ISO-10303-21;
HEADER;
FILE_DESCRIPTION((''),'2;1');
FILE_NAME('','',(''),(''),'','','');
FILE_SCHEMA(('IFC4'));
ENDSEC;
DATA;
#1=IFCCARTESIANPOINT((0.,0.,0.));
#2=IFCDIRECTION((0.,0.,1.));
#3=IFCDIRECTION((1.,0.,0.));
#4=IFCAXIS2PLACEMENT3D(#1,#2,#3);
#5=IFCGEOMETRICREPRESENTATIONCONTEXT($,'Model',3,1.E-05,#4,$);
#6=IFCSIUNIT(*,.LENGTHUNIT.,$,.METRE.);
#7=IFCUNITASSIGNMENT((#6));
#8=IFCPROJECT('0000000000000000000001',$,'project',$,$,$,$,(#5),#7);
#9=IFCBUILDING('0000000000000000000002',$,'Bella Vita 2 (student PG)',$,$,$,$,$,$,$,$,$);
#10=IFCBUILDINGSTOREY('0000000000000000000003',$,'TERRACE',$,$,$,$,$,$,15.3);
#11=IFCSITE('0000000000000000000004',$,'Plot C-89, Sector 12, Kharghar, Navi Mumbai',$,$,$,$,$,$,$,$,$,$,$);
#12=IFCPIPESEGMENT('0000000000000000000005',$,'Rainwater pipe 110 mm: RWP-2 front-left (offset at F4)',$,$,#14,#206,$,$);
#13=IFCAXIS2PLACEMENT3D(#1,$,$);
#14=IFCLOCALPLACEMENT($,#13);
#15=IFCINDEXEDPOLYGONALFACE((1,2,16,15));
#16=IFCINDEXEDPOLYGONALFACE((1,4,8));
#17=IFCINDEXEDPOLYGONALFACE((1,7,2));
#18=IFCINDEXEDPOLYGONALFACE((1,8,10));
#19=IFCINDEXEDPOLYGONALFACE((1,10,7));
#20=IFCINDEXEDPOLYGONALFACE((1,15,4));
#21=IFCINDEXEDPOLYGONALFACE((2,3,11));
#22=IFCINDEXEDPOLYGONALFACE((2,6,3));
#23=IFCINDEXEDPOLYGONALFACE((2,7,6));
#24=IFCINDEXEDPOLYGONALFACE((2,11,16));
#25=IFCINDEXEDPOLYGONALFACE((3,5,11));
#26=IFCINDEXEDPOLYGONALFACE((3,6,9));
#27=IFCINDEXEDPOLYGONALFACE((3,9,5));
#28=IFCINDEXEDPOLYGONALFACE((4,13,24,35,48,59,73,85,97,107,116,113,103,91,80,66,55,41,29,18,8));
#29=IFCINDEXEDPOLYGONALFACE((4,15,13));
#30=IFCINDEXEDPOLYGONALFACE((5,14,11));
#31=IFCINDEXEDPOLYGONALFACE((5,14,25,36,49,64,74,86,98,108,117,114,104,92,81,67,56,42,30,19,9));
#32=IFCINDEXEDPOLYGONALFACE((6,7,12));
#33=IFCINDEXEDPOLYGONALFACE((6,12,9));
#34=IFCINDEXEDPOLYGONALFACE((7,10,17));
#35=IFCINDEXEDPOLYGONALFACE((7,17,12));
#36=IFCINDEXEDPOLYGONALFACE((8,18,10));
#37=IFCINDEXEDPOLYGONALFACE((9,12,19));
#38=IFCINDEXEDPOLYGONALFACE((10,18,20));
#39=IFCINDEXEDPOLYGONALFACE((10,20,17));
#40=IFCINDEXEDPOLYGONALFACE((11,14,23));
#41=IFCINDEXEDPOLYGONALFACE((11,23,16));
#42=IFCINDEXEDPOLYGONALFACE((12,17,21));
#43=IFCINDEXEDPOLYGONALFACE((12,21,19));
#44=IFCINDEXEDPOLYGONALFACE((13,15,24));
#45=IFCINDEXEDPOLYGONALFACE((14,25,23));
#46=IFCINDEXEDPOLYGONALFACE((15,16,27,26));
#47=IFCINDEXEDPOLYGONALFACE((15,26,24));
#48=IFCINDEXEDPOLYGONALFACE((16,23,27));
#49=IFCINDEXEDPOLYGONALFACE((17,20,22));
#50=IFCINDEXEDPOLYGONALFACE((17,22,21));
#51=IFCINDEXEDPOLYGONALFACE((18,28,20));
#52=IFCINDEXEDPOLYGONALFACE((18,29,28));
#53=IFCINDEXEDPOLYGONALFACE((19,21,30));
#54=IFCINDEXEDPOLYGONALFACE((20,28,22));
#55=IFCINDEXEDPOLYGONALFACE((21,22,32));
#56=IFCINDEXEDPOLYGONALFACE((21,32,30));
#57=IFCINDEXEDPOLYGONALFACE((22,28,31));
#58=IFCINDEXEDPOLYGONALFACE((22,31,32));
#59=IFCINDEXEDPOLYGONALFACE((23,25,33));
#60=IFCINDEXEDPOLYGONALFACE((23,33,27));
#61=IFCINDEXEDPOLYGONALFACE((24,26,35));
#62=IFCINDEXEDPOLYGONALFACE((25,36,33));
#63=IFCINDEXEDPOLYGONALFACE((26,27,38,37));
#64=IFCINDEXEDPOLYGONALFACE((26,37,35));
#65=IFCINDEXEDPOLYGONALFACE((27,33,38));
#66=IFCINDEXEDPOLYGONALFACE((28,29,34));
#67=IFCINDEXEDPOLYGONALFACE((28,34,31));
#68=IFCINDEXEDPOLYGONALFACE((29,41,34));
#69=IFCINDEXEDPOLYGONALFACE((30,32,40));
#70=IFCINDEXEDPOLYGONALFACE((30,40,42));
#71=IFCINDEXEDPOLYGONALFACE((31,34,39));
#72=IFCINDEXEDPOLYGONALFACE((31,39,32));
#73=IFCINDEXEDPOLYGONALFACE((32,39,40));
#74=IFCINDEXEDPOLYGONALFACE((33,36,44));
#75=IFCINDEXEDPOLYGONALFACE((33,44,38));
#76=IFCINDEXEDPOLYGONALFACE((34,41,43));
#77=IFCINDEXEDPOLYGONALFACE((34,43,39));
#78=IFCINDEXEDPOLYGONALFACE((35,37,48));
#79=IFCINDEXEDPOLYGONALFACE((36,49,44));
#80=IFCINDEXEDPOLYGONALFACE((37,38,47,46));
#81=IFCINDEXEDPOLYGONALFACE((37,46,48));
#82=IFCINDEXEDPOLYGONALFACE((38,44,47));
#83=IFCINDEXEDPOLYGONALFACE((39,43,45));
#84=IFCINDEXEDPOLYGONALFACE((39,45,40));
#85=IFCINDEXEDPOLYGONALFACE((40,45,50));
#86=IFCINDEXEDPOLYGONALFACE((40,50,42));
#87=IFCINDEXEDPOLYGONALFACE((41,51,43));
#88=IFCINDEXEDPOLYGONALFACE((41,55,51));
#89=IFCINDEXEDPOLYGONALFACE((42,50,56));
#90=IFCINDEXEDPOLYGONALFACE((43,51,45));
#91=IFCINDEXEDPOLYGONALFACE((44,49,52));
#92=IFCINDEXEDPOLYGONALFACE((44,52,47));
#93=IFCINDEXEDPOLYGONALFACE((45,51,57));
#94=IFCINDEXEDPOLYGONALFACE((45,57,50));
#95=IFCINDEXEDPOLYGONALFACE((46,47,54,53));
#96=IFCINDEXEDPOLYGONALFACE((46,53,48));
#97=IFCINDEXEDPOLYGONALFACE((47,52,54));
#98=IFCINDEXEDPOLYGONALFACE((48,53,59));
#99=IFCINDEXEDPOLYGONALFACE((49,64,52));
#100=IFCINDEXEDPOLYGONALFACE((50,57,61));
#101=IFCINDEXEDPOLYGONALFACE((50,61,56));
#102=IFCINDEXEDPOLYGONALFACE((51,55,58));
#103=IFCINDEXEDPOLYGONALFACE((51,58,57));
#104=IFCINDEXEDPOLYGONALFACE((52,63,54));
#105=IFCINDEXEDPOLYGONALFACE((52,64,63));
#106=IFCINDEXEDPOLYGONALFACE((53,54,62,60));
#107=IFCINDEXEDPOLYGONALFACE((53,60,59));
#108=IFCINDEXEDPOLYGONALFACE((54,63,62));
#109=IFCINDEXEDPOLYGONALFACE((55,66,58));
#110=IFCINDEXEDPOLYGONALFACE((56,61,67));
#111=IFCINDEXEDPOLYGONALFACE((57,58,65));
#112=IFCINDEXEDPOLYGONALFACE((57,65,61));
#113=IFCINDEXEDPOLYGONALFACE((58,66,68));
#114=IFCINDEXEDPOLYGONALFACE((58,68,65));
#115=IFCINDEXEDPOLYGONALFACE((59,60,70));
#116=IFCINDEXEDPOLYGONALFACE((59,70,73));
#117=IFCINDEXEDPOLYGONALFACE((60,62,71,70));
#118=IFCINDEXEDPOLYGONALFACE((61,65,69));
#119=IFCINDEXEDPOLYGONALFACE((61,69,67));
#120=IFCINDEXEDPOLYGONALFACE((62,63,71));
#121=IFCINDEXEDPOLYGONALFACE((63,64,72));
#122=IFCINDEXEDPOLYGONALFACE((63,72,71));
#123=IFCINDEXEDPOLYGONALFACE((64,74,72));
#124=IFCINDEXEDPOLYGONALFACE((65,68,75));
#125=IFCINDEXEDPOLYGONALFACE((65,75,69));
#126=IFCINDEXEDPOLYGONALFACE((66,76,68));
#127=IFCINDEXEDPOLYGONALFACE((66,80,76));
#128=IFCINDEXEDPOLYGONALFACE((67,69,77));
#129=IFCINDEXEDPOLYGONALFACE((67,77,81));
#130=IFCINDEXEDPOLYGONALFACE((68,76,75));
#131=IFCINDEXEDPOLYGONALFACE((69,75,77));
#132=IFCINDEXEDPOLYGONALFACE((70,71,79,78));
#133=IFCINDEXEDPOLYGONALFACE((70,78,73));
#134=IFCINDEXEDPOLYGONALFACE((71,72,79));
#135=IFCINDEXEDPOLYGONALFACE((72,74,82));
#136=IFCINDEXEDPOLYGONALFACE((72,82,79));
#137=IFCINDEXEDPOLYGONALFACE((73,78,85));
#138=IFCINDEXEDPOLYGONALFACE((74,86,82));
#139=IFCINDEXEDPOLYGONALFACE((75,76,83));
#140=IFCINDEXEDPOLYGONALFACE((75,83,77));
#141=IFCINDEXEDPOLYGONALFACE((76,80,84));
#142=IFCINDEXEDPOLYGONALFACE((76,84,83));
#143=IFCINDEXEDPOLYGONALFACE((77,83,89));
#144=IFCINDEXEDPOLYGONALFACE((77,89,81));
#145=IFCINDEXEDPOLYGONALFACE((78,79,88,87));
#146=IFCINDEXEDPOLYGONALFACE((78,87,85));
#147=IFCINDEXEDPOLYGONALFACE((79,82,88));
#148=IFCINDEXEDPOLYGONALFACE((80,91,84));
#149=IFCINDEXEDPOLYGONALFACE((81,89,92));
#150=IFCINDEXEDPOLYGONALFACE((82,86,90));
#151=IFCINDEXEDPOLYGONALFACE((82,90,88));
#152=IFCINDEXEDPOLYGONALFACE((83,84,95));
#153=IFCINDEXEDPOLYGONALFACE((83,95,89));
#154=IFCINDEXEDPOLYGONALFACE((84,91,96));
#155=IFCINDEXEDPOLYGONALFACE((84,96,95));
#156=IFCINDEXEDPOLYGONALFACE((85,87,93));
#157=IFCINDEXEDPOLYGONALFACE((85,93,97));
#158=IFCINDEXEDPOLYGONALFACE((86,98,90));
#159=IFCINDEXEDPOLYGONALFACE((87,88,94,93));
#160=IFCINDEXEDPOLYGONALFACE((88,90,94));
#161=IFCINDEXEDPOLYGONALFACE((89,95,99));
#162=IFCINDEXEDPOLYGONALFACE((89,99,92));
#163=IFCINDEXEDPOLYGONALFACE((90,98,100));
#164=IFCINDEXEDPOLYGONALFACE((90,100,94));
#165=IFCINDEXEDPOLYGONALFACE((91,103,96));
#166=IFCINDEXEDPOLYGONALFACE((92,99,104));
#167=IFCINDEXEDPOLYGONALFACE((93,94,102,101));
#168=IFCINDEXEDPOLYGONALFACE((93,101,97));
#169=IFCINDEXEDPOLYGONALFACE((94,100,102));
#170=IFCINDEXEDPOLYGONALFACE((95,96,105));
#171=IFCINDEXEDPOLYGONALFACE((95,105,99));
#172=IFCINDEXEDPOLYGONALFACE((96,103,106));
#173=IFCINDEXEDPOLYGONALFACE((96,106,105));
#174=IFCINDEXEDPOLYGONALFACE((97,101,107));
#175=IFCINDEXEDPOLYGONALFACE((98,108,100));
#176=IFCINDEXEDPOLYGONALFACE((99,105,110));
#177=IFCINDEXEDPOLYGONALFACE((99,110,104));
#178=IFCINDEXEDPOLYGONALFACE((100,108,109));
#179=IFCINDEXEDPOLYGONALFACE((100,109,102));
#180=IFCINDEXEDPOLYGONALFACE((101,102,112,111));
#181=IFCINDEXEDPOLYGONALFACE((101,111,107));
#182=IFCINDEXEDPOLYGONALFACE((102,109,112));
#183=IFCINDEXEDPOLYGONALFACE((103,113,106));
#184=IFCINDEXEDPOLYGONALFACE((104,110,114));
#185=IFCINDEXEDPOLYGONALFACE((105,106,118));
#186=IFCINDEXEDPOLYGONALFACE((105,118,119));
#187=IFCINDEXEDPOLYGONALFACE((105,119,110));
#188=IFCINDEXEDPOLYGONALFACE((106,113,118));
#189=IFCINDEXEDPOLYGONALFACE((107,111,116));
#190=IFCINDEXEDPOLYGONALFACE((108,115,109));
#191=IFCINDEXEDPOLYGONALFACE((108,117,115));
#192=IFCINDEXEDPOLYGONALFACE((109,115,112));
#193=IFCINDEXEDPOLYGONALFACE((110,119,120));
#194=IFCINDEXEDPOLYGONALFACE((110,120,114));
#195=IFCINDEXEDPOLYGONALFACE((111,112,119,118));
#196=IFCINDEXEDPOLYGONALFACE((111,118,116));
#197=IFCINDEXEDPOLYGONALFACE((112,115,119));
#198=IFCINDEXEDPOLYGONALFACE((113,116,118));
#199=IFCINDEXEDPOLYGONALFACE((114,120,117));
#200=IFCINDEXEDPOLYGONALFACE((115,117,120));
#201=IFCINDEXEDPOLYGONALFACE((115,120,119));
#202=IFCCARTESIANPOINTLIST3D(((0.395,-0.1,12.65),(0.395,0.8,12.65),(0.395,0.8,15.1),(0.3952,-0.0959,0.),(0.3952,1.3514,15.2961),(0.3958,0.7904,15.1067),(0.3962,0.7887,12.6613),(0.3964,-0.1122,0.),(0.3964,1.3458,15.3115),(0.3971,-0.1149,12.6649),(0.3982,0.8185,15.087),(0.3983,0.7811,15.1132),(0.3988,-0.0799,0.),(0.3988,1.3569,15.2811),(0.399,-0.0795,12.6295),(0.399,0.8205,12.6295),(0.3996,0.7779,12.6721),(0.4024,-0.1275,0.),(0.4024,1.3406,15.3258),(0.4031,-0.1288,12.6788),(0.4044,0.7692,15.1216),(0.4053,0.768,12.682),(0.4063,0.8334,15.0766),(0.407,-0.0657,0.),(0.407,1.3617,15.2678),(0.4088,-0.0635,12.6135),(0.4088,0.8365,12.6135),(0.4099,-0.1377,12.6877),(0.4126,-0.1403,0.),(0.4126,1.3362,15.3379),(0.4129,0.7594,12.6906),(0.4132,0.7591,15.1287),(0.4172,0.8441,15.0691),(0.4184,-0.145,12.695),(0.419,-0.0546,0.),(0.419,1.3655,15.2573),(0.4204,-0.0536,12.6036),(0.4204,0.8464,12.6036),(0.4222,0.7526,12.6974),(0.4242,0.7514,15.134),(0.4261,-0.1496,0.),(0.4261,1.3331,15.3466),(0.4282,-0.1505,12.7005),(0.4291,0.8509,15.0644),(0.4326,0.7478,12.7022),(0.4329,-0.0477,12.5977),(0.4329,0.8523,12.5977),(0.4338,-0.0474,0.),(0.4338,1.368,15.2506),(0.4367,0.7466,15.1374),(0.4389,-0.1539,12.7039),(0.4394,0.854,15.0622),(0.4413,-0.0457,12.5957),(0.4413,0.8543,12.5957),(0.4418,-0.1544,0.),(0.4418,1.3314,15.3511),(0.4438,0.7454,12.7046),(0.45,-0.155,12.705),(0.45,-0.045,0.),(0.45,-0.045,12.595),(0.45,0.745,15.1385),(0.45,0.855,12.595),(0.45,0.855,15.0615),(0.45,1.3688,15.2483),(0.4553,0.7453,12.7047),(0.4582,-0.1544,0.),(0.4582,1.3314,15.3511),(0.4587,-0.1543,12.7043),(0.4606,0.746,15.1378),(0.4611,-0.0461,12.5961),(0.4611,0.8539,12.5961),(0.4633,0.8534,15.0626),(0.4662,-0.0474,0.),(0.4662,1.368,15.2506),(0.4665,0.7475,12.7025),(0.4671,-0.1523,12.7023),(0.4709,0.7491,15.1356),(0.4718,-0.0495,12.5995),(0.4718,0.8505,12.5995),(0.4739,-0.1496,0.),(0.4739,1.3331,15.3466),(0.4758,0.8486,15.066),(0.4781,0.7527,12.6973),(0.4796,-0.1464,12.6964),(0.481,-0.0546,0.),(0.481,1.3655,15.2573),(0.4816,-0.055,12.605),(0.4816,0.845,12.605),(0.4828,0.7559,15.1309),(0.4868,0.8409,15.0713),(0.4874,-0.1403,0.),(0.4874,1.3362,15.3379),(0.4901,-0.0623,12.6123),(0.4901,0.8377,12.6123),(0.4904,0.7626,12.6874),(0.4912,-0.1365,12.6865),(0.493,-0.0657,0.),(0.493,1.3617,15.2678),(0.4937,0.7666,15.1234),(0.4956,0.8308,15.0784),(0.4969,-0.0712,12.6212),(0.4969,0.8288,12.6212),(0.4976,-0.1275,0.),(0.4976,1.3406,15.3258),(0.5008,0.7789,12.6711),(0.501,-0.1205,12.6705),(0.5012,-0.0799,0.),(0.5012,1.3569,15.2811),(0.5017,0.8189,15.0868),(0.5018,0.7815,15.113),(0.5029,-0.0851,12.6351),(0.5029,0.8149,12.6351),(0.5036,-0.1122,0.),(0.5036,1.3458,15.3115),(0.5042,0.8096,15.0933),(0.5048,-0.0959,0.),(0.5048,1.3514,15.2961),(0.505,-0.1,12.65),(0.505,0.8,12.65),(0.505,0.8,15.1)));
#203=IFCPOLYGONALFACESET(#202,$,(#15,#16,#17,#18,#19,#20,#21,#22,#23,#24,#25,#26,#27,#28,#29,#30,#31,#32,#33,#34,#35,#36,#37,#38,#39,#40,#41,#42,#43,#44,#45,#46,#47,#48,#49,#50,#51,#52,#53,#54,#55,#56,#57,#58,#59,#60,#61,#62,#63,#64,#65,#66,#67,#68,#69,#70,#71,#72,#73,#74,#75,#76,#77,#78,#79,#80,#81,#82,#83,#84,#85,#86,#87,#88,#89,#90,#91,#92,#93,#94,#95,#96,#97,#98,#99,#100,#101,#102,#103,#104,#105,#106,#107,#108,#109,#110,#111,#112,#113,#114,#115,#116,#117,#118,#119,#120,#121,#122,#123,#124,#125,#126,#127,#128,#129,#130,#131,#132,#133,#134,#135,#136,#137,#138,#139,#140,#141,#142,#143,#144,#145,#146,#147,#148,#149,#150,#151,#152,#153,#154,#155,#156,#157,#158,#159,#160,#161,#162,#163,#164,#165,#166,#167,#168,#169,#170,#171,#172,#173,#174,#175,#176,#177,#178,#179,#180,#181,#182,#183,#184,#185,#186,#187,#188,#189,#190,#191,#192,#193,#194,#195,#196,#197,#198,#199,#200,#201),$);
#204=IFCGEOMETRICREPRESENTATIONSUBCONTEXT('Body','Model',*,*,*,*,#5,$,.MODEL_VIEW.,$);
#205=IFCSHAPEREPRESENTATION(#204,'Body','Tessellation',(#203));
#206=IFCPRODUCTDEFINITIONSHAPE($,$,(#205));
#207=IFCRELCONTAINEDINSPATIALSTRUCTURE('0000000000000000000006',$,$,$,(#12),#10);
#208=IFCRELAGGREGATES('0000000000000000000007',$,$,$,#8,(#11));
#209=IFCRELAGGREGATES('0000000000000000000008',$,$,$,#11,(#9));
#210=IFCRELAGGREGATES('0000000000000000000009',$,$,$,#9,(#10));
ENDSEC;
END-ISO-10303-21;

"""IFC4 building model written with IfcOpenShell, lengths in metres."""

from ifc_helpers import new_model, entity, si_unit, origin, origin_with_axes, place, context, subcontext, project, spatial, element, save


model = new_model("IFC4")

# Units and contexts
model_context = context("Model", 3, precision=1e-05, world=origin_with_axes())
body_context = subcontext(model_context, "Body", "Model", "MODEL_VIEW")
ifc_project = project(units=[si_unit("LENGTHUNIT", "METRE")], contexts=[model_context])

# Site, building, storey
site = spatial("IfcSite", under=ifc_project, Name="Plot C-89, Sector 12, Kharghar, Navi Mumbai")
building = spatial("IfcBuilding", under=site, Name="Bella Vita 2 (student PG)")
storey = spatial("IfcBuildingStorey", under=building, Name="TERRACE", Elevation=15.3)

# Pipe segment
pipe_segment_1_placement = place(None, origin())
element("IfcPipeSegment", 1, at=pipe_segment_1_placement, inside=storey, Name="Rainwater pipe 110 mm: RWP-2 front-left (offset at F4)", context=body_context, shape_type="AdvancedSweptSolid", body=[
    entity("IfcSweptDiskSolid", entity("IfcPolyline", [entity("IfcCartesianPoint", [0.45, 1.35, 15.3]), entity("IfcCartesianPoint", [0.45, 0.8, 15.1]), entity("IfcCartesianPoint", [0.45, 0.8, 12.65]), entity("IfcCartesianPoint", [0.45, -0.1, 12.65]), entity("IfcCartesianPoint", [0.45, -0.1, 0.0])]), 0.055),
])

save(model, "model.ifc")
